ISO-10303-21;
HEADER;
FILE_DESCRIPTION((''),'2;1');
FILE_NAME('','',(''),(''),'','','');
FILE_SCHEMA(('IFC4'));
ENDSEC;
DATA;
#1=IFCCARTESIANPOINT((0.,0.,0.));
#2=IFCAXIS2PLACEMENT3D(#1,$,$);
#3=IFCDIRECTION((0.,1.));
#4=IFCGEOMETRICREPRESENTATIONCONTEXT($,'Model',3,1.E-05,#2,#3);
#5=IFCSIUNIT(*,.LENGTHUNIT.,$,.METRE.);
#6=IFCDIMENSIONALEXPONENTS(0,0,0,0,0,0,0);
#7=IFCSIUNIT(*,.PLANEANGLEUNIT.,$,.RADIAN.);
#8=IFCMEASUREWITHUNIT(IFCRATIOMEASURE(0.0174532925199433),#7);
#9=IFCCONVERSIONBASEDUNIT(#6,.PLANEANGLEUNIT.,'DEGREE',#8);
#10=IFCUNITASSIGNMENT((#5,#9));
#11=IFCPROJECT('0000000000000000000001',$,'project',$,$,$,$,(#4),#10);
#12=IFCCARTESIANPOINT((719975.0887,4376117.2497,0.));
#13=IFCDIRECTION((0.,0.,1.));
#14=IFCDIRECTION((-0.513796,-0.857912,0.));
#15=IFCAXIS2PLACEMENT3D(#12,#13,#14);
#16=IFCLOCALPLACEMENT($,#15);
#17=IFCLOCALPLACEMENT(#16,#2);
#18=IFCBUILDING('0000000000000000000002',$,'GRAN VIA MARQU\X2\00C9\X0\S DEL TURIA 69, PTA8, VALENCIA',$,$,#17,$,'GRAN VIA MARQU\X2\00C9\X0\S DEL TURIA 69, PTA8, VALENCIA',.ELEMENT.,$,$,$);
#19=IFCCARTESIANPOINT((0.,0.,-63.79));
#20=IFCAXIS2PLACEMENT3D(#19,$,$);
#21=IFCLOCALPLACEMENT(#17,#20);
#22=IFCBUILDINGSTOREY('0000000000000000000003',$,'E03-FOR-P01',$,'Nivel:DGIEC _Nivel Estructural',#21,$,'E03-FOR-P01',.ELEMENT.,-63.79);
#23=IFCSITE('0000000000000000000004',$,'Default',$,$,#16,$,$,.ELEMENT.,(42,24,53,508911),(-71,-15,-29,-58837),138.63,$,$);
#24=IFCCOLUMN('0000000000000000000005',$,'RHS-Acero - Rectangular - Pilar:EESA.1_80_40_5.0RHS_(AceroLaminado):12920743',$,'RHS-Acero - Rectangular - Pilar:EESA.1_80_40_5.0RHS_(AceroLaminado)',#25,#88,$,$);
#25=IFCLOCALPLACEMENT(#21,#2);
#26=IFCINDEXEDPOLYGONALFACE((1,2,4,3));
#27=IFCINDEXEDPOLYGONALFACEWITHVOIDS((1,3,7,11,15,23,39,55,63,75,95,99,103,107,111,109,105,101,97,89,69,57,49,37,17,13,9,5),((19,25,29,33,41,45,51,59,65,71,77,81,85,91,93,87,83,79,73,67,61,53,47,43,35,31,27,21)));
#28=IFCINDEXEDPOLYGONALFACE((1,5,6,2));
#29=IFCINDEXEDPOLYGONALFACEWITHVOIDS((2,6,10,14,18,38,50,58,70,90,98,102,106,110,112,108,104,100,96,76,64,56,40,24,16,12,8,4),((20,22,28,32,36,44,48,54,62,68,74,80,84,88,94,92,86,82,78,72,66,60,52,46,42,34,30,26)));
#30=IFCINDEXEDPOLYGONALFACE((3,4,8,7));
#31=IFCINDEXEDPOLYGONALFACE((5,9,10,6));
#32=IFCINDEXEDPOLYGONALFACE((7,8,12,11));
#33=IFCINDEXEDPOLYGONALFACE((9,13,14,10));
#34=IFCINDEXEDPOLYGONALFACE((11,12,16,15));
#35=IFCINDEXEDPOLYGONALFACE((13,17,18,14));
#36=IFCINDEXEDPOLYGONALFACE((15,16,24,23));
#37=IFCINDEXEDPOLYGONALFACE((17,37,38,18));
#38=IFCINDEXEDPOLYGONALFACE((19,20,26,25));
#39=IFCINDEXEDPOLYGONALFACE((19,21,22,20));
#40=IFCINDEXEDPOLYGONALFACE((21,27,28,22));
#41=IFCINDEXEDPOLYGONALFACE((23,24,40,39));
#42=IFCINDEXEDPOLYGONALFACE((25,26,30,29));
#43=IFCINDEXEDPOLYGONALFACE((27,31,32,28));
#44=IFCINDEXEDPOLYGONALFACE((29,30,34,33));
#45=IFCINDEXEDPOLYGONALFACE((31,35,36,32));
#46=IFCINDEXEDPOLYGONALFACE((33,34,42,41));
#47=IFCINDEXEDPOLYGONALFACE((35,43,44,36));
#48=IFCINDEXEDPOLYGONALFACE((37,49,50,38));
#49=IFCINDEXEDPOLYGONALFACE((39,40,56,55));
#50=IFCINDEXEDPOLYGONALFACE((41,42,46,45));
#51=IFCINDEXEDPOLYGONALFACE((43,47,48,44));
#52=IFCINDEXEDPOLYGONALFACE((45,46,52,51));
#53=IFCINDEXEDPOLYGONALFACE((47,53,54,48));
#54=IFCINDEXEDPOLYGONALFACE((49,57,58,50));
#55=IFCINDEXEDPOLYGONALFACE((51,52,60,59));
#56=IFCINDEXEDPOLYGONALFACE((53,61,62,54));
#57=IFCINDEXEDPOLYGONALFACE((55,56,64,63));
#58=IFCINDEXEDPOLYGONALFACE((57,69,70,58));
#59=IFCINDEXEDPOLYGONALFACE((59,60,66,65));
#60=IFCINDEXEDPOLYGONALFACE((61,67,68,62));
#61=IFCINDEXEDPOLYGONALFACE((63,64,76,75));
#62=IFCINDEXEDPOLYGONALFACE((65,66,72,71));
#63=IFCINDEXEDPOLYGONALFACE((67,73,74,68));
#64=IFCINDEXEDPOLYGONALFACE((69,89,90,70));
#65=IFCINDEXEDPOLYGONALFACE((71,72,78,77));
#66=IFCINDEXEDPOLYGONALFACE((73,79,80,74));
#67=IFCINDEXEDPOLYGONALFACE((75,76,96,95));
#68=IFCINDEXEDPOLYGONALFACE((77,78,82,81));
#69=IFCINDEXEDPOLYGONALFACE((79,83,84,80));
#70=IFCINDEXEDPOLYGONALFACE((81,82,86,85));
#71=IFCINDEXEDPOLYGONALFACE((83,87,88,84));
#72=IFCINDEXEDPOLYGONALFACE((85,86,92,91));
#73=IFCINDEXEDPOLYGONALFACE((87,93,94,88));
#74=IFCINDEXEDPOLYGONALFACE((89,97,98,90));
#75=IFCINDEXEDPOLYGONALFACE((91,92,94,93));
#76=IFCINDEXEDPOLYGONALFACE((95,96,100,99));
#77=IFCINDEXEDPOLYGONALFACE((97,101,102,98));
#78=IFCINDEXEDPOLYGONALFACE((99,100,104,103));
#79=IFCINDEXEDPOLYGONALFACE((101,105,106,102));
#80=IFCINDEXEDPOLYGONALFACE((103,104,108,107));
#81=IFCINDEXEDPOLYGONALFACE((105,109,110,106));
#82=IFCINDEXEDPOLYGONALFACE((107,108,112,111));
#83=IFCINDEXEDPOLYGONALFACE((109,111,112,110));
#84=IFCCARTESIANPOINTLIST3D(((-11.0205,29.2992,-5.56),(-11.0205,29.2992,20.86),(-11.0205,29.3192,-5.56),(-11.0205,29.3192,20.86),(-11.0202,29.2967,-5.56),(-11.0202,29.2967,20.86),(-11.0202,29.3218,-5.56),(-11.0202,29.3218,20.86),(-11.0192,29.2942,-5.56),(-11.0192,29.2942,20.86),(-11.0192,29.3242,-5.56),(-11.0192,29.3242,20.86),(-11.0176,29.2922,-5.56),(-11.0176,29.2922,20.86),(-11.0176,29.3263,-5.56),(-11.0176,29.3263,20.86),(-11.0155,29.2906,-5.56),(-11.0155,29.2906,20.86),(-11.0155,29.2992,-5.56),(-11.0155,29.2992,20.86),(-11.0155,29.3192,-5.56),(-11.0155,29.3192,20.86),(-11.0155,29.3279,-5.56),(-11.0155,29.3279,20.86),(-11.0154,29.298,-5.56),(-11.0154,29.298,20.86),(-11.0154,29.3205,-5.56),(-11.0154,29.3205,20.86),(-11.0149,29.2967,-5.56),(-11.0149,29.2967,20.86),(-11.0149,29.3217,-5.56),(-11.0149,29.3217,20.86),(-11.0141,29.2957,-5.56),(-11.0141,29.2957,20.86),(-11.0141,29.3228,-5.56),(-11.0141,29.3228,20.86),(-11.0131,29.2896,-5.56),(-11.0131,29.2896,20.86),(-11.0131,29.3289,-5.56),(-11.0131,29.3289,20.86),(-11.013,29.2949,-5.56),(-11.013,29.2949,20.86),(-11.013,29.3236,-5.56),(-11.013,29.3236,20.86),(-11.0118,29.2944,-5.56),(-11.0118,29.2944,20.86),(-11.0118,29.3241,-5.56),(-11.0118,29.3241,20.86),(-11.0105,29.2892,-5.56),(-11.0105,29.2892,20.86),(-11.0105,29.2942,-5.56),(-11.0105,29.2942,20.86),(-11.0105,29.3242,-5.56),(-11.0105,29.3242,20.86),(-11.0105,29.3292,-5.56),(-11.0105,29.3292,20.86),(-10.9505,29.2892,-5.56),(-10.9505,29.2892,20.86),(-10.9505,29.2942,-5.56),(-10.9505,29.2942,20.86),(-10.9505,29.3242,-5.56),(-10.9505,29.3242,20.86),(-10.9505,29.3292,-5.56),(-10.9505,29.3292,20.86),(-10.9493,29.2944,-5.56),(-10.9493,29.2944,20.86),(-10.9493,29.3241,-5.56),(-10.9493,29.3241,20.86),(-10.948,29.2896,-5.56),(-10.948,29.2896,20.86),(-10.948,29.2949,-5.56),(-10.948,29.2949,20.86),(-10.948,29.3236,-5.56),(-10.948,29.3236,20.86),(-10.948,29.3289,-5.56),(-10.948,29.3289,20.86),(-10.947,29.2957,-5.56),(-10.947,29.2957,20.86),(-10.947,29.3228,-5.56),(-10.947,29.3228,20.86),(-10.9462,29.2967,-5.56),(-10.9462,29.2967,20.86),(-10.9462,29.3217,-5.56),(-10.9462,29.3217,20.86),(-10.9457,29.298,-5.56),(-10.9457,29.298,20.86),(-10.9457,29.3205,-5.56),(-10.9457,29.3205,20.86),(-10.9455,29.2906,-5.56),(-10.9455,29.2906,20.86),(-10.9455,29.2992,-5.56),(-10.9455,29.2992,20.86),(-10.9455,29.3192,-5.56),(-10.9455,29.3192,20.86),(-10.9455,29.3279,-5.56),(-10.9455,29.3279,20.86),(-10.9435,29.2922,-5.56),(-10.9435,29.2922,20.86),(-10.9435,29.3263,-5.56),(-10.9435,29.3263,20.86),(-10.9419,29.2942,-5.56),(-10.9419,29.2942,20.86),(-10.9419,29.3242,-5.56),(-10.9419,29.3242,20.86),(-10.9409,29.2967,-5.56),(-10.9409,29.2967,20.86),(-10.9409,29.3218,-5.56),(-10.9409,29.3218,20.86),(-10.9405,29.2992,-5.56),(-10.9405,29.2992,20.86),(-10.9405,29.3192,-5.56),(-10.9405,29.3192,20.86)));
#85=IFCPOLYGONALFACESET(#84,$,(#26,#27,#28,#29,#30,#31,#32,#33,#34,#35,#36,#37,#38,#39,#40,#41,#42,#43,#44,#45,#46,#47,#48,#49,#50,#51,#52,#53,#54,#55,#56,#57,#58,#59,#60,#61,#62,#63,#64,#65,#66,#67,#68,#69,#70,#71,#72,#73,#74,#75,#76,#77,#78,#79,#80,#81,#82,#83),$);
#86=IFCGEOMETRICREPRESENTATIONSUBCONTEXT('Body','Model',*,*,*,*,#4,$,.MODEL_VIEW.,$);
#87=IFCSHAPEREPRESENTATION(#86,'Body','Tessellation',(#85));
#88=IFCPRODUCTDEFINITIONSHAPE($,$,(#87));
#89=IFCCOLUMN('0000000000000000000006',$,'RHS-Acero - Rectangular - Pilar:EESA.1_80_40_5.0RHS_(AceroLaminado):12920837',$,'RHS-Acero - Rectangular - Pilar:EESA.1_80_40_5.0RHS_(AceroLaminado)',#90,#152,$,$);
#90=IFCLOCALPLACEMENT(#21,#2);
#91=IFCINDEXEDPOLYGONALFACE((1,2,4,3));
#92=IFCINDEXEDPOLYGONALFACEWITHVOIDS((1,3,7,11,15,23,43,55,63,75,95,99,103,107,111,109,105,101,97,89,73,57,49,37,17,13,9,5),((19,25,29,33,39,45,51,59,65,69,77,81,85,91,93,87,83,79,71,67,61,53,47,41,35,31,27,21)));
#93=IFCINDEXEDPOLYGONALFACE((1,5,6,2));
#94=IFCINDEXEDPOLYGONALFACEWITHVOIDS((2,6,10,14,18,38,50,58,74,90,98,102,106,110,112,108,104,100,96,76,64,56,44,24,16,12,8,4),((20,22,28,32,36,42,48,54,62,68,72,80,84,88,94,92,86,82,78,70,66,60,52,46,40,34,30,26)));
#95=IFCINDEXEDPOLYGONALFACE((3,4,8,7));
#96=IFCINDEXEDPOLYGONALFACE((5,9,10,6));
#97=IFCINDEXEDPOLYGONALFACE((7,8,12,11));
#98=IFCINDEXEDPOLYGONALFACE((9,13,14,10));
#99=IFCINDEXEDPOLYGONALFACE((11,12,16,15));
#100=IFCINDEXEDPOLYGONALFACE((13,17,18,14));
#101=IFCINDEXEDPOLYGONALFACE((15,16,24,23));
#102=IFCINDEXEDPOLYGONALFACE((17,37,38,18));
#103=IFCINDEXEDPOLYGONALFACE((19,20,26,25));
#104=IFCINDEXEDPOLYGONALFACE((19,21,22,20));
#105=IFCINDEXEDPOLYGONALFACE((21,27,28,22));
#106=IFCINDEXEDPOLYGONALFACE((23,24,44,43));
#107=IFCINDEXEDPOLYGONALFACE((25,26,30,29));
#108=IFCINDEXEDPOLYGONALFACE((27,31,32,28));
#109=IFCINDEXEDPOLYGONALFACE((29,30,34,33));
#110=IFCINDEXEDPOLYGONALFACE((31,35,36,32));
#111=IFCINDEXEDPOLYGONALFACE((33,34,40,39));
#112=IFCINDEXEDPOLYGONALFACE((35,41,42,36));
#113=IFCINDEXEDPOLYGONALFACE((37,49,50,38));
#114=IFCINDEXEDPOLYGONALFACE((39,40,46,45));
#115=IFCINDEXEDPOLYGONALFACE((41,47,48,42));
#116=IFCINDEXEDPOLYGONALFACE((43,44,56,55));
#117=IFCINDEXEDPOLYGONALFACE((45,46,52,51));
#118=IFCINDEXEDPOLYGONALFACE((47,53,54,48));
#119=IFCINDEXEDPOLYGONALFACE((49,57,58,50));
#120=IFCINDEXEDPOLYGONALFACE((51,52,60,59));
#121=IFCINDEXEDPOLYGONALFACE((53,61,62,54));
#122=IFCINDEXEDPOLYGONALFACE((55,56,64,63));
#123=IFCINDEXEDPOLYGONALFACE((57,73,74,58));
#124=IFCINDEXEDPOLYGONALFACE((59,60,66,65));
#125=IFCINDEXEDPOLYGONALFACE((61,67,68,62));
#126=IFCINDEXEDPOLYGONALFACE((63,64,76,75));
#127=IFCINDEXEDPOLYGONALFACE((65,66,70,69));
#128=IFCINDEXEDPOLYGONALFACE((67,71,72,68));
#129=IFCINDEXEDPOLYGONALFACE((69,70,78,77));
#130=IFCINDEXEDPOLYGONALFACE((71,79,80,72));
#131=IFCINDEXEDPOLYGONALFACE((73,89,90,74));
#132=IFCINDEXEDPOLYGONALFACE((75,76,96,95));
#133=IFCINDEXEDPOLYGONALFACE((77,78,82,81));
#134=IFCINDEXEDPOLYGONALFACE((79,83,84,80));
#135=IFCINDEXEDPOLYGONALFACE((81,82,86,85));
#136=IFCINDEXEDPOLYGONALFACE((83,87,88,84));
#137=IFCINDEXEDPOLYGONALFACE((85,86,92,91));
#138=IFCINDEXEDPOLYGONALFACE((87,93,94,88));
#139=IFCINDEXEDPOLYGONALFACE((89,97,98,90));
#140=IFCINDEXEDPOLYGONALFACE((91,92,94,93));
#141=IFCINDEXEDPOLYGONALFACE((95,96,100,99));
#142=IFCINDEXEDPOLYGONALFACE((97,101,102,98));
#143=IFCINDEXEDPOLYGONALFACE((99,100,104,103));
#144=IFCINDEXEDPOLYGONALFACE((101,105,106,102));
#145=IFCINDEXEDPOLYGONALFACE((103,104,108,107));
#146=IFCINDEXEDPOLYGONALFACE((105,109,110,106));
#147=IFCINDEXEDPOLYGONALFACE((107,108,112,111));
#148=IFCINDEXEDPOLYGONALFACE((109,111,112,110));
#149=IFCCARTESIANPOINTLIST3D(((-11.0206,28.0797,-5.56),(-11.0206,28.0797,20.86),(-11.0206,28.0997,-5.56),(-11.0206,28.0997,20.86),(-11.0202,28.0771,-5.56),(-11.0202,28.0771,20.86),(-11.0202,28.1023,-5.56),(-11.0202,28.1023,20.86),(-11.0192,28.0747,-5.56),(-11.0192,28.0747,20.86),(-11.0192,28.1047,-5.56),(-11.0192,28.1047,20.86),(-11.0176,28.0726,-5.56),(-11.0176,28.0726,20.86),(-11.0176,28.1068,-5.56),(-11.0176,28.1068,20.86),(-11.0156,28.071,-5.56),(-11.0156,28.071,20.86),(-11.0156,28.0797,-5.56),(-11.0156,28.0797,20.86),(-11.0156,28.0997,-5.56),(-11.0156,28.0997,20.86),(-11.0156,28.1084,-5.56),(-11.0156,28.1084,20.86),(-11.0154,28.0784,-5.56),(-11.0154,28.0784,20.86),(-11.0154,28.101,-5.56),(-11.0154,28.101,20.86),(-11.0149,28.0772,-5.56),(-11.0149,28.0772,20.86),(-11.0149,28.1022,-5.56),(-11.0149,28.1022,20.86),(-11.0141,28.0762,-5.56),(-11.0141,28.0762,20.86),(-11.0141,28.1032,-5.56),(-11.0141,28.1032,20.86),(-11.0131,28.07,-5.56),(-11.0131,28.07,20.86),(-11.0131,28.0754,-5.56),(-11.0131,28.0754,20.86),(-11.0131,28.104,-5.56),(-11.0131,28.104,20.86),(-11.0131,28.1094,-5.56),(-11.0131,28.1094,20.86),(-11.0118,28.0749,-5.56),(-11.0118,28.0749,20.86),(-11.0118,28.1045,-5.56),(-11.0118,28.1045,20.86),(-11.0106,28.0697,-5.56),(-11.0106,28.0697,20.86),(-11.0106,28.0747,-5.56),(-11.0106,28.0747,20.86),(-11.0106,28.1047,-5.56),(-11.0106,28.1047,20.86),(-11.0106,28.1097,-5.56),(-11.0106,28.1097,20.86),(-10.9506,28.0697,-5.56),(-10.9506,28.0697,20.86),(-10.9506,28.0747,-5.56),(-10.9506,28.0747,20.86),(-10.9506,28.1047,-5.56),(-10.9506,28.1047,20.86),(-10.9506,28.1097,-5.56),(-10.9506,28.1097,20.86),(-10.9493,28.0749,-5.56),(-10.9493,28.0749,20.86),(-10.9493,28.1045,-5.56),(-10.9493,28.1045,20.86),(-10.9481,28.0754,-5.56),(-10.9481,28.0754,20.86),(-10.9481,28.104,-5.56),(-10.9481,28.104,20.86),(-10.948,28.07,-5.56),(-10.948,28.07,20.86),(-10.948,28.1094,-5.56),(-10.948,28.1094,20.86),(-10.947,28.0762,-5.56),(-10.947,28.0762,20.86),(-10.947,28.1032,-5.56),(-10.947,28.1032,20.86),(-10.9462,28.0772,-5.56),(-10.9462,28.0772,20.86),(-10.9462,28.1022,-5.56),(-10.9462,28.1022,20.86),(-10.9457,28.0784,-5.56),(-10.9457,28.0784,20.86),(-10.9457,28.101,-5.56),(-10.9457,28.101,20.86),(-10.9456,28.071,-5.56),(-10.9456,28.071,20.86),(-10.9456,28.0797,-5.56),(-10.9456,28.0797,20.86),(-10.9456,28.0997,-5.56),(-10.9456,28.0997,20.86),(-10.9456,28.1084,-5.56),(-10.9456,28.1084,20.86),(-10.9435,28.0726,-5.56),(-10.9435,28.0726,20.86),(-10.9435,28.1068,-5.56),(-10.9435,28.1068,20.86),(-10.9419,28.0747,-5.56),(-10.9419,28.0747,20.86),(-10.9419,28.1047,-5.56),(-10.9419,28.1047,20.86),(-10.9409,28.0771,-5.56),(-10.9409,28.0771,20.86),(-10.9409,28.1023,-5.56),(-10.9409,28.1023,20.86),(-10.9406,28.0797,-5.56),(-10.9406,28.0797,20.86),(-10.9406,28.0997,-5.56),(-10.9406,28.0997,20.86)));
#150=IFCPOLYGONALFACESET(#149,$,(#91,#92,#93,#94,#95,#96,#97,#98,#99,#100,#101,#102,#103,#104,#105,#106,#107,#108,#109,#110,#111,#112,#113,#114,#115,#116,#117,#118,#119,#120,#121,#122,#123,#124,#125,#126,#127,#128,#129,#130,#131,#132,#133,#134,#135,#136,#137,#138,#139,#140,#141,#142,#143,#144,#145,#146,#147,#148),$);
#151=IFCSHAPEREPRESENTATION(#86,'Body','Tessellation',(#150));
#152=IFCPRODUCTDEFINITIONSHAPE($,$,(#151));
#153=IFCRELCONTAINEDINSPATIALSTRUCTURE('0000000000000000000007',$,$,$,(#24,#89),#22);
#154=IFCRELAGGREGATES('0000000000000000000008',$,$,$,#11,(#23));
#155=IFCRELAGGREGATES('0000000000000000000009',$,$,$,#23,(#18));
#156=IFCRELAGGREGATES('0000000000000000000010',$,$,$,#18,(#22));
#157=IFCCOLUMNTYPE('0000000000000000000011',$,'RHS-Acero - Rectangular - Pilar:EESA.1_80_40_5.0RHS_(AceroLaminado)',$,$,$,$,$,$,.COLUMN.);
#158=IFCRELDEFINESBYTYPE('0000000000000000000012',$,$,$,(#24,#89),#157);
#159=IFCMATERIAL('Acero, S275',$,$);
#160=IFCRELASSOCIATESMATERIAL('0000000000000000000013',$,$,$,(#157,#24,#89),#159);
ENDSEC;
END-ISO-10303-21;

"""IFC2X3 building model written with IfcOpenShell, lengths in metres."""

from ifc_helpers import new_model, entity, si_unit, converted_unit, direction, frame, frame_2d, origin, place, context, subcontext, project, spatial, polyline, circle_curve, parameter, trimmed, segment, composite_curve, outline, extrude, source, transform, mapped, material, type_object, type_shapes, element, save


model = new_model("IFC2X3")

# Units and contexts
model_context = context("Model", 3, precision=1e-05, world=origin(), true_north=direction((0.0, 1.0)))
body_context = subcontext(model_context, "Body", "Model", "MODEL_VIEW")
ifc_project = project(units=[si_unit("LENGTHUNIT", "METRE"), converted_unit("PLANEANGLEUNIT", "DEGREE", entity("IfcRatioMeasure", 0.0174532925199433), si_unit("PLANEANGLEUNIT", "RADIAN"), dimensions=[0, 0, 0, 0, 0, 0, 0])], contexts=[model_context])

# Site, building, storey
site_placement = place(None, frame((719975.0887, 4376117.2497, 0.0), z_axis=(0.0, 0.0, 1.0), x_axis=(-0.513796, -0.857912, 0.0)))
site = spatial("IfcSite", under=ifc_project, at=site_placement, Name="Default", CompositionType="ELEMENT", RefLatitude=(42, 24, 53, 508911), RefLongitude=(-71, -15, -29, -58837), RefElevation=138.63)
building_placement = place(site_placement, origin())
building = spatial("IfcBuilding", under=site, at=building_placement, Name="GRAN VIA MARQUÉS DEL TURIA 69, PTA8, VALENCIA", LongName="GRAN VIA MARQUÉS DEL TURIA 69, PTA8, VALENCIA", CompositionType="ELEMENT")
storey_placement = place(building_placement, frame((0.0, 0.0, -63.79)))
storey = spatial("IfcBuildingStorey", under=building, at=storey_placement, Name="E03-FOR-P01", ObjectType="Nivel:DGIEC _Nivel Estructural", LongName="E03-FOR-P01", CompositionType="ELEMENT", Elevation=-63.79)

# Columns
ifc_material_1 = material(Name="Acero, S275")
column_type_1 = type_object("IfcColumnType", Name="RHS-Acero - Rectangular - Pilar:EESA.1_80_40_5.0RHS_(AceroLaminado)", PredefinedType="COLUMN", material=ifc_material_1)
shared_shape_1 = source(origin(), body_context, "Body", "SweptSolid", [
    extrude(outline(composite_curve([segment(polyline([(-0.01, -0.04), (0.01, -0.04)]), True, "CONTINUOUS"), segment(trimmed(circle_curve(frame_2d((0.01, -0.03), x_axis=(-1.0, 0.0)), 0.01), [parameter(90.0)], [parameter(180.0)], True, "PARAMETER"), True, "CONTINUOUS"), segment(polyline([(0.02, -0.03), (0.02, 0.03)]), True, "CONTINUOUS"), segment(trimmed(circle_curve(frame_2d((0.01, 0.03), x_axis=(-1.0, 0.0)), 0.01), [parameter(180.0)], [parameter(270.0)], True, "PARAMETER"), True, "CONTINUOUS"), segment(polyline([(0.01, 0.04), (-0.01, 0.04)]), True, "CONTINUOUS"), segment(trimmed(circle_curve(frame_2d((-0.01, 0.03), x_axis=(-1.0, 0.0)), 0.01), [parameter(270.0)], [parameter(360.0)], True, "PARAMETER"), True, "CONTINUOUS"), segment(polyline([(-0.02, 0.03), (-0.02, -0.03)]), True, "CONTINUOUS"), segment(trimmed(circle_curve(frame_2d((-0.01, -0.03), x_axis=(-1.0, 0.0)), 0.01), [parameter(360.0)], [parameter(90.0)], True, "PARAMETER"), True, "CONTINUOUS")], self_intersect=False), holes=[composite_curve([segment(trimmed(circle_curve(frame_2d((-0.01, -0.03), x_axis=(-1.0, 0.0)), 0.005), [parameter(0.0)], [parameter(90.0)], True, "PARAMETER"), False, "CONTINUOUS"), segment(polyline([(-0.015, -0.03), (-0.015, 0.03)]), True, "CONTINUOUS"), segment(trimmed(circle_curve(frame_2d((-0.01, 0.03), x_axis=(-1.0, 0.0)), 0.005), [parameter(270.0)], [parameter(0.0)], True, "PARAMETER"), False, "CONTINUOUS"), segment(polyline([(-0.01, 0.035), (0.01, 0.035)]), True, "CONTINUOUS"), segment(trimmed(circle_curve(frame_2d((0.01, 0.03), x_axis=(-1.0, 0.0)), 0.005), [parameter(180.0)], [parameter(270.0)], True, "PARAMETER"), False, "CONTINUOUS"), segment(polyline([(0.015, 0.03), (0.015, -0.03)]), True, "CONTINUOUS"), segment(trimmed(circle_curve(frame_2d((0.01, -0.03), x_axis=(-1.0, 0.0)), 0.005), [parameter(90.0)], [parameter(180.0)], True, "PARAMETER"), False, "CONTINUOUS"), segment(polyline([(0.01, -0.035), (-0.01, -0.035)]), True, "CONTINUOUS")], self_intersect=False)]), frame((0.0, 0.0, -69.35), z_axis=(0.0, 0.0, 1.0), x_axis=(-1.0, 0.0, 0.0)), (0.0, 0.0, 1.0), 26.42),
])
type_shapes(column_type_1, [shared_shape_1])
for number, where, z_axis, x_axis, name in (
    (1, (-10.9805, 29.3092, 63.79), (0.0, 0.0, 1.0), (0.0, 1.0, 0.0), "RHS-Acero - Rectangular - Pilar:EESA.1_80_40_5.0RHS_(AceroLaminado):12920743"),
    (2, (-10.9806, 28.0897, 63.79), (0.0, 0.0, 1.0), (0.0, 1.0, 0.0), "RHS-Acero - Rectangular - Pilar:EESA.1_80_40_5.0RHS_(AceroLaminado):12920837"),
):
    element("IfcColumn", number, at=place(storey_placement, frame(where, z_axis=z_axis, x_axis=x_axis)), inside=storey, type_object=column_type_1, material=ifc_material_1, Name=name, ObjectType="RHS-Acero - Rectangular - Pilar:EESA.1_80_40_5.0RHS_(AceroLaminado)", context=body_context, shape_type="MappedRepresentation", body=[
        mapped(shared_shape_1, transform((0.0, 0.0, 0.0), scale=1.0)),
    ])

save(model, "model.ifc")
